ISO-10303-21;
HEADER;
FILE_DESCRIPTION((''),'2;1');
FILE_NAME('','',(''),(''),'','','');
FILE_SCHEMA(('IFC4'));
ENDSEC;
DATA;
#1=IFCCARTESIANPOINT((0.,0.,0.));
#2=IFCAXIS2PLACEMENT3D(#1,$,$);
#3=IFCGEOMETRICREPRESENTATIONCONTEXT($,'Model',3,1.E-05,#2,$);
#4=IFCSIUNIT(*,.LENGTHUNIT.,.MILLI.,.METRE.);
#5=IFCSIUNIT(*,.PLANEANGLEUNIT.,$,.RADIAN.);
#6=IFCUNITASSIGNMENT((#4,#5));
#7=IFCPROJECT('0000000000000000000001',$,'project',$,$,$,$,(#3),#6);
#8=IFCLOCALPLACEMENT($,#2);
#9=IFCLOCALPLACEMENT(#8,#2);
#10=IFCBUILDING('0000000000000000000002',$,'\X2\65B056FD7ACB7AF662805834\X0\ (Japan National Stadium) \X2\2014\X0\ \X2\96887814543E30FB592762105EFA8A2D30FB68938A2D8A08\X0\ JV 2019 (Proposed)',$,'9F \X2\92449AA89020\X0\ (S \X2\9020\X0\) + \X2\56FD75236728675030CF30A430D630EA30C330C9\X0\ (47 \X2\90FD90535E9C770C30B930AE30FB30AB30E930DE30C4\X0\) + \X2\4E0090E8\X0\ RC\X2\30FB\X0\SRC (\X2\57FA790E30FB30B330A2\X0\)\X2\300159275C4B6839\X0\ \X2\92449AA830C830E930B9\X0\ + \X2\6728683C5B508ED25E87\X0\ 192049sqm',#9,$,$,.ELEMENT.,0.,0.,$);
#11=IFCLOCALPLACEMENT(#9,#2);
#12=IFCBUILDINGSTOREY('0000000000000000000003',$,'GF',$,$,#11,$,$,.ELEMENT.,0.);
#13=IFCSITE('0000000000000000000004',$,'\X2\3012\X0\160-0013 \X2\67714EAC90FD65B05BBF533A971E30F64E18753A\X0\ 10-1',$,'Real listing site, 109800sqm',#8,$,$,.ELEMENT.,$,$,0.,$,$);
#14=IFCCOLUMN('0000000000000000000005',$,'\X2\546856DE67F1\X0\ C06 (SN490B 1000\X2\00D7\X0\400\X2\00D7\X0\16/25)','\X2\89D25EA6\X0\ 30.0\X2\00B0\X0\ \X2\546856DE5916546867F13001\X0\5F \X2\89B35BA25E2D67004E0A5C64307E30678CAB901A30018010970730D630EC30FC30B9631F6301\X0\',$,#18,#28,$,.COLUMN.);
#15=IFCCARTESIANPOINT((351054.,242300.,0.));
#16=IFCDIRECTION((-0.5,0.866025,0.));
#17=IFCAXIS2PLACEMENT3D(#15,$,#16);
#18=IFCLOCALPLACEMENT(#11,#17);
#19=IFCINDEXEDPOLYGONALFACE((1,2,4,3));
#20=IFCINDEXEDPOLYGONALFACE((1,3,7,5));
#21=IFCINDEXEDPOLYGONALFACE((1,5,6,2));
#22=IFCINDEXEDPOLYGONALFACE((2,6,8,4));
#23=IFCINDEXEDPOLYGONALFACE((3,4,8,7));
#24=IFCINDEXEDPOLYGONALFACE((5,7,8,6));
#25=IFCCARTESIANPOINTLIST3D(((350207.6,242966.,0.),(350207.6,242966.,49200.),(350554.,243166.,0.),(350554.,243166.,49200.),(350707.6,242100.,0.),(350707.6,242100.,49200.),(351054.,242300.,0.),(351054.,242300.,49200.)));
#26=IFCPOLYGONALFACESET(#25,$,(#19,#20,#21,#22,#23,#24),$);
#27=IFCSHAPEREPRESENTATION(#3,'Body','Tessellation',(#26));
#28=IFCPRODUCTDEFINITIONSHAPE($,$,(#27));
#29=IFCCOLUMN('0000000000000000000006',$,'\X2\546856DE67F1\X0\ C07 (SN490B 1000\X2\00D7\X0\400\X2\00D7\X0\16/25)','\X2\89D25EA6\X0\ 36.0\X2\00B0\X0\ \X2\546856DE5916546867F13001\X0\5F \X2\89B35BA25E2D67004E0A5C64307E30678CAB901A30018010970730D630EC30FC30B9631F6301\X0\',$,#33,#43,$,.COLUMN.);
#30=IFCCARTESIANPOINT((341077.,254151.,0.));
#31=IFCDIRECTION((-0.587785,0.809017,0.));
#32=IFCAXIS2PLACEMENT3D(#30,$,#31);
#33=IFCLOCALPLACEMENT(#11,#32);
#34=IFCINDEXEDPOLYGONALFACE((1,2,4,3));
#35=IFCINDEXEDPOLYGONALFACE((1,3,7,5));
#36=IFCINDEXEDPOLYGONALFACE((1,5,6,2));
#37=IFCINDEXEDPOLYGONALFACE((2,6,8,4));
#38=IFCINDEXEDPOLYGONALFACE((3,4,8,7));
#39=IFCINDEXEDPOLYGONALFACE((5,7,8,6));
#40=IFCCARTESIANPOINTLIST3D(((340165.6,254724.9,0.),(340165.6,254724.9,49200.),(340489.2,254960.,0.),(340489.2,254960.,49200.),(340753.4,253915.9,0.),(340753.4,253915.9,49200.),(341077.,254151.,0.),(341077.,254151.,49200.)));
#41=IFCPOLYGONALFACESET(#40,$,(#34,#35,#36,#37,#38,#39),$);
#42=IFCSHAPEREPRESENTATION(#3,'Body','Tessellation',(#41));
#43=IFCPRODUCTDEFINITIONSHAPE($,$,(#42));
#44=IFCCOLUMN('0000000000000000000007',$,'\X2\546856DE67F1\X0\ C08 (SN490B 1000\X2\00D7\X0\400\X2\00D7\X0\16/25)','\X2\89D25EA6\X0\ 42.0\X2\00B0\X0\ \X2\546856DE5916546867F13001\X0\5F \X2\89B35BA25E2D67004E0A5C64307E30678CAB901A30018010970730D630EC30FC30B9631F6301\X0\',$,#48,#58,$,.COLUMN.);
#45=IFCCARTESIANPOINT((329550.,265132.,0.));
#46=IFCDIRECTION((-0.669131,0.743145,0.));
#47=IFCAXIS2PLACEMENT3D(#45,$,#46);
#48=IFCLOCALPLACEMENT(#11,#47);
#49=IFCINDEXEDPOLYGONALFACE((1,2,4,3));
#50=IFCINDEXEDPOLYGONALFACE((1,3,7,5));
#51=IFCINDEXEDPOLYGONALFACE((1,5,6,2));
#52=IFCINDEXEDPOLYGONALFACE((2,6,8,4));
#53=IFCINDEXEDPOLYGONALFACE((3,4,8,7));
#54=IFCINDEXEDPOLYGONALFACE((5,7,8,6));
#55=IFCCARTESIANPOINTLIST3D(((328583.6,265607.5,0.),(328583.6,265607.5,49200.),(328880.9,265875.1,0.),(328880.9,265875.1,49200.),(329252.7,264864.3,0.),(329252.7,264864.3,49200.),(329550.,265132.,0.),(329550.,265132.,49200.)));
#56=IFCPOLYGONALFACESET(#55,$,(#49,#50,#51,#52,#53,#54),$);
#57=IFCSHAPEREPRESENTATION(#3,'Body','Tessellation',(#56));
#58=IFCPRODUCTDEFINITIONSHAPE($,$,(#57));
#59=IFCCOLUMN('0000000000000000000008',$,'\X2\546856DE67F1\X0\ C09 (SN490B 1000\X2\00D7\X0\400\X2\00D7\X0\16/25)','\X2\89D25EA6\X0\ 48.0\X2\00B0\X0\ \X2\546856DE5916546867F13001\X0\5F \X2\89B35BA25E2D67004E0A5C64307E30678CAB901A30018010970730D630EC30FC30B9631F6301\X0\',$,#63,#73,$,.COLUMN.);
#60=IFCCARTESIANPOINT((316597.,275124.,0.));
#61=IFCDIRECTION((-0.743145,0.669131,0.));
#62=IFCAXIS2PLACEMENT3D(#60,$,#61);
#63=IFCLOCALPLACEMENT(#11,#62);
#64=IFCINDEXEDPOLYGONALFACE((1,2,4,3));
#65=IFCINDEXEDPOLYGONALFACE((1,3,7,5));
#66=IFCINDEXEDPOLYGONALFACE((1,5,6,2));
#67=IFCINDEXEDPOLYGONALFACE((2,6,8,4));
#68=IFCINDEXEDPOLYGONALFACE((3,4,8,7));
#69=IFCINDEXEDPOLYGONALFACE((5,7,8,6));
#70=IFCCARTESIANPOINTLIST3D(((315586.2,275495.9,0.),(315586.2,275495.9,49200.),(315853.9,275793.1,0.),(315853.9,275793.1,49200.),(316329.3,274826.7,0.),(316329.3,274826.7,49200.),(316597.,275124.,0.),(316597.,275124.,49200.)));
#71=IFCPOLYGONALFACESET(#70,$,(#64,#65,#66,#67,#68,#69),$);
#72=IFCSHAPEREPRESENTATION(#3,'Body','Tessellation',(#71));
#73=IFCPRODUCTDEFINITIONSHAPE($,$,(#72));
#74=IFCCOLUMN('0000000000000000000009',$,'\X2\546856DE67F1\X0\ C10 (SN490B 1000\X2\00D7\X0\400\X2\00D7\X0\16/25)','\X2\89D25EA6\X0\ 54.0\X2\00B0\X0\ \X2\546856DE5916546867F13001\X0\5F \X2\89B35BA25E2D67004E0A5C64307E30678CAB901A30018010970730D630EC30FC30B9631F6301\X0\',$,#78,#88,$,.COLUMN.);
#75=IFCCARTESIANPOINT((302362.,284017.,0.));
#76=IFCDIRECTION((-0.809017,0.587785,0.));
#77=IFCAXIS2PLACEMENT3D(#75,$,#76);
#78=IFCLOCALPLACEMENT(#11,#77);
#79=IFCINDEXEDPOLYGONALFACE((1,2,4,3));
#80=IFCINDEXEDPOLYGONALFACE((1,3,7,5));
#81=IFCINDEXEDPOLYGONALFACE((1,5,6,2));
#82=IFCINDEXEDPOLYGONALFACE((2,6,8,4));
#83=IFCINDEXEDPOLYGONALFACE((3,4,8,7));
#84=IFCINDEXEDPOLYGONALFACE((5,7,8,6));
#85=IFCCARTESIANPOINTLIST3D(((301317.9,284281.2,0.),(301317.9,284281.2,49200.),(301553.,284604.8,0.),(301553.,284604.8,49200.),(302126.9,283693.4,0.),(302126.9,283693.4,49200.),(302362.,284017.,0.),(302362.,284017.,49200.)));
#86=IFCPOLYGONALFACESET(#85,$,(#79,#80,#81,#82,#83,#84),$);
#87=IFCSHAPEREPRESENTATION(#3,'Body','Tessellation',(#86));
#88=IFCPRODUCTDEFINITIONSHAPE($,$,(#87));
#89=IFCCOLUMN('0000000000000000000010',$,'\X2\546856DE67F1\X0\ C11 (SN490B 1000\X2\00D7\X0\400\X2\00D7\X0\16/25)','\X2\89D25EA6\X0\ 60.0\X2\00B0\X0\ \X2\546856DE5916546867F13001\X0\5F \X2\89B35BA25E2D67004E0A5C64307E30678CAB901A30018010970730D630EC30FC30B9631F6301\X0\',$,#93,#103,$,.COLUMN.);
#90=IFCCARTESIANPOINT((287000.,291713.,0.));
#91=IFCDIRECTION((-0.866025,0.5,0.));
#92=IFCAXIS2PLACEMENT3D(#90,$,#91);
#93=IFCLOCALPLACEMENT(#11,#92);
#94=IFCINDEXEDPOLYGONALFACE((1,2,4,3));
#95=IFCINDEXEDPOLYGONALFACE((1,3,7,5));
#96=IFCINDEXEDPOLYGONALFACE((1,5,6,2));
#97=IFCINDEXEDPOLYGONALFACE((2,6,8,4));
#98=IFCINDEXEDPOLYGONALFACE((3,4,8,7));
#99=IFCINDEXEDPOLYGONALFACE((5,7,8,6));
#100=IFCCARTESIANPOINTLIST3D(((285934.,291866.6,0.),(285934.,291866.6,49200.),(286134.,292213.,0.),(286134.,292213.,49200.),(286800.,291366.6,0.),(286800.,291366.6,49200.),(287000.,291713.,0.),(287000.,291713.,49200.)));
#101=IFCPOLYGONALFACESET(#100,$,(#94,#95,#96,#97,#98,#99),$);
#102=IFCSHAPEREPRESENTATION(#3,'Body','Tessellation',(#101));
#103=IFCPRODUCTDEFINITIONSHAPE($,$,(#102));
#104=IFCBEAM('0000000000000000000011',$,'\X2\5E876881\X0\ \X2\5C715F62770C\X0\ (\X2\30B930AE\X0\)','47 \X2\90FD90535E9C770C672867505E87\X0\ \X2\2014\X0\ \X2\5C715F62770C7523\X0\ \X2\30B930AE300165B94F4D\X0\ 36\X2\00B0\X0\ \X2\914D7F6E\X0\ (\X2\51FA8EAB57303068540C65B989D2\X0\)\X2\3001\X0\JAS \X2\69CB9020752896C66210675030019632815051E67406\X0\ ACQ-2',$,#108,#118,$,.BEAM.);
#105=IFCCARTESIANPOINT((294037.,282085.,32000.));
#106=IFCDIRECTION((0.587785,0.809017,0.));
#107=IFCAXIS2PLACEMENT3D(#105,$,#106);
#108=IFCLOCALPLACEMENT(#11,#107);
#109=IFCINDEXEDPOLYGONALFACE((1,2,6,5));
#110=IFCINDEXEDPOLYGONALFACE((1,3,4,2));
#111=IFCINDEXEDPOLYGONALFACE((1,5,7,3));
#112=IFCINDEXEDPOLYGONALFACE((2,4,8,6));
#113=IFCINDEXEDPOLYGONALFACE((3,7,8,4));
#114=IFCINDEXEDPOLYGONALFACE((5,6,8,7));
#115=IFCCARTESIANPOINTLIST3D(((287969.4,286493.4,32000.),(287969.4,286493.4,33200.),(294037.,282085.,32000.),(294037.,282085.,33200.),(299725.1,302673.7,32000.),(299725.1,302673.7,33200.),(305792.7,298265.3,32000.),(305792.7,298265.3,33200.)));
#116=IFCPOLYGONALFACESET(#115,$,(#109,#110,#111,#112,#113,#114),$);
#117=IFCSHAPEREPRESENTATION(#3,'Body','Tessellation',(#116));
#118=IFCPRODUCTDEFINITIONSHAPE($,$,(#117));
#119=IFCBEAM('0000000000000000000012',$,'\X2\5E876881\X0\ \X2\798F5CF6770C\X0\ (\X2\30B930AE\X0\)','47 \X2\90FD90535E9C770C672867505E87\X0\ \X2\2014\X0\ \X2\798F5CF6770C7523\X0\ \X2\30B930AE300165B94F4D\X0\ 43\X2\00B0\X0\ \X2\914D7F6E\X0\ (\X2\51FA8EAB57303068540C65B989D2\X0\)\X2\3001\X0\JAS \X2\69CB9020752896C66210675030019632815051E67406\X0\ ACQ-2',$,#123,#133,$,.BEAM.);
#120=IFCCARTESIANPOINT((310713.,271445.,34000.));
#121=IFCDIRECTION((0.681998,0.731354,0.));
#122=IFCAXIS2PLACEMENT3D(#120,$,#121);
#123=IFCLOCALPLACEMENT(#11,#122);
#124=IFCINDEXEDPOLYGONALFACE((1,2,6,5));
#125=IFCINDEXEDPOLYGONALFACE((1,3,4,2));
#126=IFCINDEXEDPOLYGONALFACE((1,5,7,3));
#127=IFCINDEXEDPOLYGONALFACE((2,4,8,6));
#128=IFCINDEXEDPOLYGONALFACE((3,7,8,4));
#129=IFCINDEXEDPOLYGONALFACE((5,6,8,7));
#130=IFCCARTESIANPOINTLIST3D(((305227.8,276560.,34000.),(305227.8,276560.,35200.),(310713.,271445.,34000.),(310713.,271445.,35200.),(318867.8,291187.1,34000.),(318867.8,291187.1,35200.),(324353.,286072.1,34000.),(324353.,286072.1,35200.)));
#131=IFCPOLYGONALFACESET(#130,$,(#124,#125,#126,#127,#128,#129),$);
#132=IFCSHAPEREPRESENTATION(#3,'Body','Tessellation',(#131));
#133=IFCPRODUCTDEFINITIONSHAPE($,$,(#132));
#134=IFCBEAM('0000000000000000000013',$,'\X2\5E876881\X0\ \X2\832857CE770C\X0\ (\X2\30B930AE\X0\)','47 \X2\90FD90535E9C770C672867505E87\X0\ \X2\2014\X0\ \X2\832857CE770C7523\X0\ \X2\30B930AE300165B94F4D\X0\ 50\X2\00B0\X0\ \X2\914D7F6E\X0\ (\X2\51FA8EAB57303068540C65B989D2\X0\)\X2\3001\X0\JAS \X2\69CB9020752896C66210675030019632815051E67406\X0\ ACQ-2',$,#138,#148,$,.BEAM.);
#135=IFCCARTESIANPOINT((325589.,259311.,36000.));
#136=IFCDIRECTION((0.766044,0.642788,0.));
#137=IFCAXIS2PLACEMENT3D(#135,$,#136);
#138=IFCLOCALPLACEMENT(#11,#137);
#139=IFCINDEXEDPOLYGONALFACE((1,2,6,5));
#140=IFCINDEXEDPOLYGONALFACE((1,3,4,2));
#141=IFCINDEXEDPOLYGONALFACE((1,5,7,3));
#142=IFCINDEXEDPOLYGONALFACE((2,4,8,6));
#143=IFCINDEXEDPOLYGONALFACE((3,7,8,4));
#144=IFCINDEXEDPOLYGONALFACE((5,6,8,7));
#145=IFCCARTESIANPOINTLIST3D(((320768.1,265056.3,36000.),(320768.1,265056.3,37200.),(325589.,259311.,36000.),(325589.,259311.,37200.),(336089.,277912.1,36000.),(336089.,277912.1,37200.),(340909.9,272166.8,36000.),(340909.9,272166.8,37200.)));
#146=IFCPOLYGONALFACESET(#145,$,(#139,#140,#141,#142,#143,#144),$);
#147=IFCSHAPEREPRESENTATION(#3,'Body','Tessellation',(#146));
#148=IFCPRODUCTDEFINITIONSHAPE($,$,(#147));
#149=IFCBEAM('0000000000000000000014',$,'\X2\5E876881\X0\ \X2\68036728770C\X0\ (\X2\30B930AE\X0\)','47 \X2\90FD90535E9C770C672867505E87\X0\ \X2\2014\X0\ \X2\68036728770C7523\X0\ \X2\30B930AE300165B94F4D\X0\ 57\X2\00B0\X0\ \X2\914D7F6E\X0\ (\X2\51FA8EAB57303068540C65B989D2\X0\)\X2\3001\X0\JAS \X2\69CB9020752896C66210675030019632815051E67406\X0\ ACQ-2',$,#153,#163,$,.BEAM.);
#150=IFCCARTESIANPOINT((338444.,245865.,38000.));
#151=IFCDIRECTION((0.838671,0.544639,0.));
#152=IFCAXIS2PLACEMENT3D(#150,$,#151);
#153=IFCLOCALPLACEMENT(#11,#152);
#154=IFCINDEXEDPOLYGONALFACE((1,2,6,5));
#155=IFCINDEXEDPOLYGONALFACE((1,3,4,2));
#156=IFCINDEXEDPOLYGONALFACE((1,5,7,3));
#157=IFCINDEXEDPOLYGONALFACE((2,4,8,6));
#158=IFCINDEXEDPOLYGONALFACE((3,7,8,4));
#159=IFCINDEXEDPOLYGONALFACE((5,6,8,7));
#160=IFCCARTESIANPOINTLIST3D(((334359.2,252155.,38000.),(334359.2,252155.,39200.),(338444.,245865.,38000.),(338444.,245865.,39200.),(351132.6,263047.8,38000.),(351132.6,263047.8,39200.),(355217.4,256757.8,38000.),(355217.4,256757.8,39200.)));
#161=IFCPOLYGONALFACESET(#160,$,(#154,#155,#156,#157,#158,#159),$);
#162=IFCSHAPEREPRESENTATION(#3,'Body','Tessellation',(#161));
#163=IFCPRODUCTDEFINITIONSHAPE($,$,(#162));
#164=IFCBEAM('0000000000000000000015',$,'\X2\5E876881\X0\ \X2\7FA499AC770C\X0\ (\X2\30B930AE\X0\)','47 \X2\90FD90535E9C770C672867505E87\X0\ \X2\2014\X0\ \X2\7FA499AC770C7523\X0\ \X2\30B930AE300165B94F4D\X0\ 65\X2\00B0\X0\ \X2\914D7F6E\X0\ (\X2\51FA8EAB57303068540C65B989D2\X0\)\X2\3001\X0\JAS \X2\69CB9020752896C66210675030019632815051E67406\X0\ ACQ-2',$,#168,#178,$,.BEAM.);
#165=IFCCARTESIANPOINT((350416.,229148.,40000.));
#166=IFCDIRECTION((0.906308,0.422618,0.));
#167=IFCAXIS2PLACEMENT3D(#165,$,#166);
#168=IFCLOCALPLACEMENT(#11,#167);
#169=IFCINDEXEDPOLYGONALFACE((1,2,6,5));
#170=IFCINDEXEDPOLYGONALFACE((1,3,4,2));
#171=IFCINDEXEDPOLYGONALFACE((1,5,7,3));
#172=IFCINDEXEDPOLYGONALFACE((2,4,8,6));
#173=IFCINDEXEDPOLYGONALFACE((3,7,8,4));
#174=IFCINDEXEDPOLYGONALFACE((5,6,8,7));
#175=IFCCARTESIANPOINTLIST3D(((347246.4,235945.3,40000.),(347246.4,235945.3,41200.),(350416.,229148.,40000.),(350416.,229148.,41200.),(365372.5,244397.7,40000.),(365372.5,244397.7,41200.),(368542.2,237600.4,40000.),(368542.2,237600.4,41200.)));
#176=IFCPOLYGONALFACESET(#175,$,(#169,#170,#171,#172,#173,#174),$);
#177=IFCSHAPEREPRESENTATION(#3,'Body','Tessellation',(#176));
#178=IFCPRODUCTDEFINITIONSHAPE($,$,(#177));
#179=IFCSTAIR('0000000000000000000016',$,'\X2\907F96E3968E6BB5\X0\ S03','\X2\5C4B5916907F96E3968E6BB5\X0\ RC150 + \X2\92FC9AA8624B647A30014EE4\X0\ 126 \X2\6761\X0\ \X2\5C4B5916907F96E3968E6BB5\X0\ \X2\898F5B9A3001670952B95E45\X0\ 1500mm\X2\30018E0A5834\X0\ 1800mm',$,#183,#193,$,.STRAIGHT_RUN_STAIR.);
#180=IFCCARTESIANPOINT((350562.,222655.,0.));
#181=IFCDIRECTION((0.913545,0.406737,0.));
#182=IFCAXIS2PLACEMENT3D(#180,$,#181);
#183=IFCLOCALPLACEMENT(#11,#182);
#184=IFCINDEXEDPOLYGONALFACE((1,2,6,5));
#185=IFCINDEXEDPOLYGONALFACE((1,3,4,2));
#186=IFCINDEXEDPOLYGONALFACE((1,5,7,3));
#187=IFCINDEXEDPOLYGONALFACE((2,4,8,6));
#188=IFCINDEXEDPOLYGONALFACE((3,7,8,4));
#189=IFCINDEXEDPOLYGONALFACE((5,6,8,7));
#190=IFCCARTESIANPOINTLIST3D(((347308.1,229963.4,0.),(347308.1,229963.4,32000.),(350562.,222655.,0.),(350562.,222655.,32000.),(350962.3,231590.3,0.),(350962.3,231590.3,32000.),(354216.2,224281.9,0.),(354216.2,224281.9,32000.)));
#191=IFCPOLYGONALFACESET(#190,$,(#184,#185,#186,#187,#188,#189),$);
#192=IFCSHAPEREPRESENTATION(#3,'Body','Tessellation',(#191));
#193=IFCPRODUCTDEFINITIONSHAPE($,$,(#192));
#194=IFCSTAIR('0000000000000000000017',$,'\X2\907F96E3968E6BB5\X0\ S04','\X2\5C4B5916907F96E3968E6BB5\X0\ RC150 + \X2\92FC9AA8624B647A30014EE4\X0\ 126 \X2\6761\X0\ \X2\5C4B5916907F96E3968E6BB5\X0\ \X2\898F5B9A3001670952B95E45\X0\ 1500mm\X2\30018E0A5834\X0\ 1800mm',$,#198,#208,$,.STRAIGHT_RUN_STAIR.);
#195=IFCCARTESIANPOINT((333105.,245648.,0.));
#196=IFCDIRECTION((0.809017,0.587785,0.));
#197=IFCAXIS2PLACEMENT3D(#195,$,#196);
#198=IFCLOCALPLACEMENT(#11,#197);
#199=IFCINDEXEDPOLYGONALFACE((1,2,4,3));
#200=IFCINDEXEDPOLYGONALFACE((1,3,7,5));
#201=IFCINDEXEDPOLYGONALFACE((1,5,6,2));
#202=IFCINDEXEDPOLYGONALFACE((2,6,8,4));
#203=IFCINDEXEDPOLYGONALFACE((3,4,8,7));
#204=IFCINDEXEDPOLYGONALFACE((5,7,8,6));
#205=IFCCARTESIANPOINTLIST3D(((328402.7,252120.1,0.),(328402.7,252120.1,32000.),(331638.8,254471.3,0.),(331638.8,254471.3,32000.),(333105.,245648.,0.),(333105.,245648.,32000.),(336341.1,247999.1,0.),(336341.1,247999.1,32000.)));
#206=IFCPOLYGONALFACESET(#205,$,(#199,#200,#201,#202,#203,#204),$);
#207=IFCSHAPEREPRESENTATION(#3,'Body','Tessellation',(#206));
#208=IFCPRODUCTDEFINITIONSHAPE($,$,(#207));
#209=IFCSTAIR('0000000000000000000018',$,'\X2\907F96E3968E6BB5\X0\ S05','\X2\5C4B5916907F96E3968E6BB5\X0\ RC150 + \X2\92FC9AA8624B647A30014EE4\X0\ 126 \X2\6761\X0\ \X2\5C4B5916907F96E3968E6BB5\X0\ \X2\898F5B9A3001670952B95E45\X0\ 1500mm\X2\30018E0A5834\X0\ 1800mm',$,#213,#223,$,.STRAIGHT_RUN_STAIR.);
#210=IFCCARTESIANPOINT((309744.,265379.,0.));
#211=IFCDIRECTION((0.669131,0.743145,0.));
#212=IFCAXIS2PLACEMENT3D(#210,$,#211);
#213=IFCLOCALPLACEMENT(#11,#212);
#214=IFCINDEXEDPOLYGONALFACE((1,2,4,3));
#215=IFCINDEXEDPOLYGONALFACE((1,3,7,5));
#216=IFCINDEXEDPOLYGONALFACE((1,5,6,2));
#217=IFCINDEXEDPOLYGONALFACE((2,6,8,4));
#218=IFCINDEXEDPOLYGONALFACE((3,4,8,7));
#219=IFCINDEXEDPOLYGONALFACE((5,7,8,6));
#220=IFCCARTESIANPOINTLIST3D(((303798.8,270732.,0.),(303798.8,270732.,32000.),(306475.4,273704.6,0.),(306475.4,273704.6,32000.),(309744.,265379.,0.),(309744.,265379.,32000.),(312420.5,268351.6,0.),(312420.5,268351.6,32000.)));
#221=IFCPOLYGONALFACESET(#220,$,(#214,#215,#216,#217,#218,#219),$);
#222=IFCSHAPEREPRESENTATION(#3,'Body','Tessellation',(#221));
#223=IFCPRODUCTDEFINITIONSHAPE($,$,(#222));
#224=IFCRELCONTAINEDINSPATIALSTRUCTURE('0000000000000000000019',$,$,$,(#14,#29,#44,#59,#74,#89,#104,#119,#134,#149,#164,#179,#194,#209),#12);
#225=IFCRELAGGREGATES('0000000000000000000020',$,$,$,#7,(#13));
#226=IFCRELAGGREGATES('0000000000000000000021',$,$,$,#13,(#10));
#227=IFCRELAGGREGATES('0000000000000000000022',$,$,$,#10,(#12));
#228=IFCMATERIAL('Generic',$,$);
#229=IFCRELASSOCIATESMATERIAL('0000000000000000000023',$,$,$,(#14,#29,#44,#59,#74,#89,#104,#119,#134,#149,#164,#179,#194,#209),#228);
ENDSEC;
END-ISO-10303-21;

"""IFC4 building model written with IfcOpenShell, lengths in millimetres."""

from ifc_helpers import new_model, si_unit, frame, frame_2d, origin, place, context, project, spatial, rectangle, extrude, material, element, save


model = new_model("IFC4")

# Units and contexts
model_context = context("Model", 3, precision=1e-05, world=origin())
ifc_project = project(units=[si_unit("LENGTHUNIT", "METRE", prefix="MILLI"), si_unit("PLANEANGLEUNIT", "RADIAN")], contexts=[model_context])

# Site, building, storey
site_placement = place(None, origin())
site = spatial("IfcSite", under=ifc_project, at=site_placement, Name="〒160-0013 東京都新宿区霞ヶ丘町 10-1", ObjectType="Real listing site, 109800sqm", CompositionType="ELEMENT", RefElevation=0.0)
building_placement = place(site_placement, origin())
building = spatial("IfcBuilding", under=site, at=building_placement, Name="新国立競技場 (Japan National Stadium) — 隈研吾・大成建設・梓設計 JV 2019 (Proposed)", ObjectType="9F 鉄骨造 (S 造) + 国産木材ハイブリッド (47 都道府県スギ・カラマツ) + 一部 RC・SRC (基礎・コア)、大屋根 鉄骨トラス + 木格子軒庇 192049sqm", CompositionType="ELEMENT", ElevationOfRefHeight=0.0, ElevationOfTerrain=0.0)
storey_placement = place(building_placement, origin())
storey = spatial("IfcBuildingStorey", under=building, at=storey_placement, Name="GF", CompositionType="ELEMENT", Elevation=0.0)

# Columns
ifc_material_1 = material(Name="Generic")
column_1_placement = place(storey_placement, frame((351054.0, 242300.0, 0.0), x_axis=(-0.5, 0.866025, 0.0)))
element("IfcColumn", 1, at=column_1_placement, inside=storey, material=ifc_material_1, Name="周回柱 C06 (SN490B 1000×400×16/25)", Description="角度 30.0° 周回外周柱、5F 観客席最上層まで貫通、耐震ブレース挟持", PredefinedType="COLUMN", context=model_context, shape_type="SweptSolid", body=[
    extrude(rectangle(XDim=1000.0, YDim=400.0, at=frame_2d((500.0, 200.0))), frame((351054.0, 242300.0, 0.0), x_axis=(-0.5, 0.866025, 0.0)), (0.0, 0.0, 1.0), 49200.0),
])
column_2_placement = place(storey_placement, frame((341077.0, 254151.0, 0.0), x_axis=(-0.587785, 0.809017, 0.0)))
element("IfcColumn", 2, at=column_2_placement, inside=storey, material=ifc_material_1, Name="周回柱 C07 (SN490B 1000×400×16/25)", Description="角度 36.0° 周回外周柱、5F 観客席最上層まで貫通、耐震ブレース挟持", PredefinedType="COLUMN", context=model_context, shape_type="SweptSolid", body=[
    extrude(rectangle(XDim=1000.0, YDim=400.0, at=frame_2d((500.0, 200.0))), frame((341077.0, 254151.0, 0.0), x_axis=(-0.587785, 0.809017, 0.0)), (0.0, 0.0, 1.0), 49200.0),
])
column_3_placement = place(storey_placement, frame((329550.0, 265132.0, 0.0), x_axis=(-0.669131, 0.743145, 0.0)))
element("IfcColumn", 3, at=column_3_placement, inside=storey, material=ifc_material_1, Name="周回柱 C08 (SN490B 1000×400×16/25)", Description="角度 42.0° 周回外周柱、5F 観客席最上層まで貫通、耐震ブレース挟持", PredefinedType="COLUMN", context=model_context, shape_type="SweptSolid", body=[
    extrude(rectangle(XDim=1000.0, YDim=400.0, at=frame_2d((500.0, 200.0))), frame((329550.0, 265132.0, 0.0), x_axis=(-0.669131, 0.743145, 0.0)), (0.0, 0.0, 1.0), 49200.0),
])
column_4_placement = place(storey_placement, frame((316597.0, 275124.0, 0.0), x_axis=(-0.743145, 0.669131, 0.0)))
element("IfcColumn", 4, at=column_4_placement, inside=storey, material=ifc_material_1, Name="周回柱 C09 (SN490B 1000×400×16/25)", Description="角度 48.0° 周回外周柱、5F 観客席最上層まで貫通、耐震ブレース挟持", PredefinedType="COLUMN", context=model_context, shape_type="SweptSolid", body=[
    extrude(rectangle(XDim=1000.0, YDim=400.0, at=frame_2d((500.0, 200.0))), frame((316597.0, 275124.0, 0.0), x_axis=(-0.743145, 0.669131, 0.0)), (0.0, 0.0, 1.0), 49200.0),
])
column_5_placement = place(storey_placement, frame((302362.0, 284017.0, 0.0), x_axis=(-0.809017, 0.587785, 0.0)))
element("IfcColumn", 5, at=column_5_placement, inside=storey, material=ifc_material_1, Name="周回柱 C10 (SN490B 1000×400×16/25)", Description="角度 54.0° 周回外周柱、5F 観客席最上層まで貫通、耐震ブレース挟持", PredefinedType="COLUMN", context=model_context, shape_type="SweptSolid", body=[
    extrude(rectangle(XDim=1000.0, YDim=400.0, at=frame_2d((500.0, 200.0))), frame((302362.0, 284017.0, 0.0), x_axis=(-0.809017, 0.587785, 0.0)), (0.0, 0.0, 1.0), 49200.0),
])
column_6_placement = place(storey_placement, frame((287000.0, 291713.0, 0.0), x_axis=(-0.866025, 0.5, 0.0)))
element("IfcColumn", 6, at=column_6_placement, inside=storey, material=ifc_material_1, Name="周回柱 C11 (SN490B 1000×400×16/25)", Description="角度 60.0° 周回外周柱、5F 観客席最上層まで貫通、耐震ブレース挟持", PredefinedType="COLUMN", context=model_context, shape_type="SweptSolid", body=[
    extrude(rectangle(XDim=1000.0, YDim=400.0, at=frame_2d((500.0, 200.0))), frame((287000.0, 291713.0, 0.0), x_axis=(-0.866025, 0.5, 0.0)), (0.0, 0.0, 1.0), 49200.0),
])

# Beams
beam_1_placement = place(storey_placement, frame((294037.0, 282085.0, 32000.0), x_axis=(0.587785, 0.809017, 0.0)))
element("IfcBeam", 7, at=beam_1_placement, inside=storey, material=ifc_material_1, Name="庇梁 山形県 (スギ)", Description="47 都道府県木材庇 — 山形県産 スギ、方位 36° 配置 (出身地と同方角)、JAS 構造用集成材、防腐処理 ACQ-2", PredefinedType="BEAM", context=model_context, shape_type="SweptSolid", body=[
    extrude(rectangle(XDim=20000.0, YDim=7500.0, at=frame_2d((10000.0, 3750.0))), frame((294037.0, 282085.0, 32000.0), x_axis=(0.587785, 0.809017, 0.0)), (0.0, 0.0, 1.0), 1200.0),
])
beam_2_placement = place(storey_placement, frame((310713.0, 271445.0, 34000.0), x_axis=(0.681998, 0.731354, 0.0)))
element("IfcBeam", 8, at=beam_2_placement, inside=storey, material=ifc_material_1, Name="庇梁 福島県 (スギ)", Description="47 都道府県木材庇 — 福島県産 スギ、方位 43° 配置 (出身地と同方角)、JAS 構造用集成材、防腐処理 ACQ-2", PredefinedType="BEAM", context=model_context, shape_type="SweptSolid", body=[
    extrude(rectangle(XDim=20000.0, YDim=7500.0, at=frame_2d((10000.0, 3750.0))), frame((310713.0, 271445.0, 34000.0), x_axis=(0.681998, 0.731354, 0.0)), (0.0, 0.0, 1.0), 1200.0),
])
beam_3_placement = place(storey_placement, frame((325589.0, 259311.0, 36000.0), x_axis=(0.766044, 0.642788, 0.0)))
element("IfcBeam", 9, at=beam_3_placement, inside=storey, material=ifc_material_1, Name="庇梁 茨城県 (スギ)", Description="47 都道府県木材庇 — 茨城県産 スギ、方位 50° 配置 (出身地と同方角)、JAS 構造用集成材、防腐処理 ACQ-2", PredefinedType="BEAM", context=model_context, shape_type="SweptSolid", body=[
    extrude(rectangle(XDim=20000.0, YDim=7500.0, at=frame_2d((10000.0, 3750.0))), frame((325589.0, 259311.0, 36000.0), x_axis=(0.766044, 0.642788, 0.0)), (0.0, 0.0, 1.0), 1200.0),
])
beam_4_placement = place(storey_placement, frame((338444.0, 245865.0, 38000.0), x_axis=(0.838671, 0.544639, 0.0)))
element("IfcBeam", 10, at=beam_4_placement, inside=storey, material=ifc_material_1, Name="庇梁 栃木県 (スギ)", Description="47 都道府県木材庇 — 栃木県産 スギ、方位 57° 配置 (出身地と同方角)、JAS 構造用集成材、防腐処理 ACQ-2", PredefinedType="BEAM", context=model_context, shape_type="SweptSolid", body=[
    extrude(rectangle(XDim=20000.0, YDim=7500.0, at=frame_2d((10000.0, 3750.0))), frame((338444.0, 245865.0, 38000.0), x_axis=(0.838671, 0.544639, 0.0)), (0.0, 0.0, 1.0), 1200.0),
])
beam_5_placement = place(storey_placement, frame((350416.0, 229148.0, 40000.0), x_axis=(0.906308, 0.422618, 0.0)))
element("IfcBeam", 11, at=beam_5_placement, inside=storey, material=ifc_material_1, Name="庇梁 群馬県 (スギ)", Description="47 都道府県木材庇 — 群馬県産 スギ、方位 65° 配置 (出身地と同方角)、JAS 構造用集成材、防腐処理 ACQ-2", PredefinedType="BEAM", context=model_context, shape_type="SweptSolid", body=[
    extrude(rectangle(XDim=20000.0, YDim=7500.0, at=frame_2d((10000.0, 3750.0))), frame((350416.0, 229148.0, 40000.0), x_axis=(0.906308, 0.422618, 0.0)), (0.0, 0.0, 1.0), 1200.0),
])

# Stairs
stair_1_placement = place(storey_placement, frame((350562.0, 222655.0, 0.0), x_axis=(0.913545, 0.406737, 0.0)))
element("IfcStair", 12, at=stair_1_placement, inside=storey, material=ifc_material_1, Name="避難階段 S03", Description="屋外避難階段 RC150 + 鋼骨手摺、令 126 条 屋外避難階段 規定、有効幅 1500mm、踊場 1800mm", PredefinedType="STRAIGHT_RUN_STAIR", context=model_context, shape_type="SweptSolid", body=[
    extrude(rectangle(XDim=4000.0, YDim=8000.0, at=frame_2d((2000.0, 4000.0))), frame((350562.0, 222655.0, 0.0), x_axis=(0.913545, 0.406737, 0.0)), (0.0, 0.0, 1.0), 32000.0),
])
stair_2_placement = place(storey_placement, frame((333105.0, 245648.0, 0.0), x_axis=(0.809017, 0.587785, 0.0)))
element("IfcStair", 13, at=stair_2_placement, inside=storey, material=ifc_material_1, Name="避難階段 S04", Description="屋外避難階段 RC150 + 鋼骨手摺、令 126 条 屋外避難階段 規定、有効幅 1500mm、踊場 1800mm", PredefinedType="STRAIGHT_RUN_STAIR", context=model_context, shape_type="SweptSolid", body=[
    extrude(rectangle(XDim=4000.0, YDim=8000.0, at=frame_2d((2000.0, 4000.0))), frame((333105.0, 245648.0, 0.0), x_axis=(0.809017, 0.587785, 0.0)), (0.0, 0.0, 1.0), 32000.0),
])
stair_3_placement = place(storey_placement, frame((309744.0, 265379.0, 0.0), x_axis=(0.669131, 0.743145, 0.0)))
element("IfcStair", 14, at=stair_3_placement, inside=storey, material=ifc_material_1, Name="避難階段 S05", Description="屋外避難階段 RC150 + 鋼骨手摺、令 126 条 屋外避難階段 規定、有効幅 1500mm、踊場 1800mm", PredefinedType="STRAIGHT_RUN_STAIR", context=model_context, shape_type="SweptSolid", body=[
    extrude(rectangle(XDim=4000.0, YDim=8000.0, at=frame_2d((2000.0, 4000.0))), frame((309744.0, 265379.0, 0.0), x_axis=(0.669131, 0.743145, 0.0)), (0.0, 0.0, 1.0), 32000.0),
])

save(model, "model.ifc")
